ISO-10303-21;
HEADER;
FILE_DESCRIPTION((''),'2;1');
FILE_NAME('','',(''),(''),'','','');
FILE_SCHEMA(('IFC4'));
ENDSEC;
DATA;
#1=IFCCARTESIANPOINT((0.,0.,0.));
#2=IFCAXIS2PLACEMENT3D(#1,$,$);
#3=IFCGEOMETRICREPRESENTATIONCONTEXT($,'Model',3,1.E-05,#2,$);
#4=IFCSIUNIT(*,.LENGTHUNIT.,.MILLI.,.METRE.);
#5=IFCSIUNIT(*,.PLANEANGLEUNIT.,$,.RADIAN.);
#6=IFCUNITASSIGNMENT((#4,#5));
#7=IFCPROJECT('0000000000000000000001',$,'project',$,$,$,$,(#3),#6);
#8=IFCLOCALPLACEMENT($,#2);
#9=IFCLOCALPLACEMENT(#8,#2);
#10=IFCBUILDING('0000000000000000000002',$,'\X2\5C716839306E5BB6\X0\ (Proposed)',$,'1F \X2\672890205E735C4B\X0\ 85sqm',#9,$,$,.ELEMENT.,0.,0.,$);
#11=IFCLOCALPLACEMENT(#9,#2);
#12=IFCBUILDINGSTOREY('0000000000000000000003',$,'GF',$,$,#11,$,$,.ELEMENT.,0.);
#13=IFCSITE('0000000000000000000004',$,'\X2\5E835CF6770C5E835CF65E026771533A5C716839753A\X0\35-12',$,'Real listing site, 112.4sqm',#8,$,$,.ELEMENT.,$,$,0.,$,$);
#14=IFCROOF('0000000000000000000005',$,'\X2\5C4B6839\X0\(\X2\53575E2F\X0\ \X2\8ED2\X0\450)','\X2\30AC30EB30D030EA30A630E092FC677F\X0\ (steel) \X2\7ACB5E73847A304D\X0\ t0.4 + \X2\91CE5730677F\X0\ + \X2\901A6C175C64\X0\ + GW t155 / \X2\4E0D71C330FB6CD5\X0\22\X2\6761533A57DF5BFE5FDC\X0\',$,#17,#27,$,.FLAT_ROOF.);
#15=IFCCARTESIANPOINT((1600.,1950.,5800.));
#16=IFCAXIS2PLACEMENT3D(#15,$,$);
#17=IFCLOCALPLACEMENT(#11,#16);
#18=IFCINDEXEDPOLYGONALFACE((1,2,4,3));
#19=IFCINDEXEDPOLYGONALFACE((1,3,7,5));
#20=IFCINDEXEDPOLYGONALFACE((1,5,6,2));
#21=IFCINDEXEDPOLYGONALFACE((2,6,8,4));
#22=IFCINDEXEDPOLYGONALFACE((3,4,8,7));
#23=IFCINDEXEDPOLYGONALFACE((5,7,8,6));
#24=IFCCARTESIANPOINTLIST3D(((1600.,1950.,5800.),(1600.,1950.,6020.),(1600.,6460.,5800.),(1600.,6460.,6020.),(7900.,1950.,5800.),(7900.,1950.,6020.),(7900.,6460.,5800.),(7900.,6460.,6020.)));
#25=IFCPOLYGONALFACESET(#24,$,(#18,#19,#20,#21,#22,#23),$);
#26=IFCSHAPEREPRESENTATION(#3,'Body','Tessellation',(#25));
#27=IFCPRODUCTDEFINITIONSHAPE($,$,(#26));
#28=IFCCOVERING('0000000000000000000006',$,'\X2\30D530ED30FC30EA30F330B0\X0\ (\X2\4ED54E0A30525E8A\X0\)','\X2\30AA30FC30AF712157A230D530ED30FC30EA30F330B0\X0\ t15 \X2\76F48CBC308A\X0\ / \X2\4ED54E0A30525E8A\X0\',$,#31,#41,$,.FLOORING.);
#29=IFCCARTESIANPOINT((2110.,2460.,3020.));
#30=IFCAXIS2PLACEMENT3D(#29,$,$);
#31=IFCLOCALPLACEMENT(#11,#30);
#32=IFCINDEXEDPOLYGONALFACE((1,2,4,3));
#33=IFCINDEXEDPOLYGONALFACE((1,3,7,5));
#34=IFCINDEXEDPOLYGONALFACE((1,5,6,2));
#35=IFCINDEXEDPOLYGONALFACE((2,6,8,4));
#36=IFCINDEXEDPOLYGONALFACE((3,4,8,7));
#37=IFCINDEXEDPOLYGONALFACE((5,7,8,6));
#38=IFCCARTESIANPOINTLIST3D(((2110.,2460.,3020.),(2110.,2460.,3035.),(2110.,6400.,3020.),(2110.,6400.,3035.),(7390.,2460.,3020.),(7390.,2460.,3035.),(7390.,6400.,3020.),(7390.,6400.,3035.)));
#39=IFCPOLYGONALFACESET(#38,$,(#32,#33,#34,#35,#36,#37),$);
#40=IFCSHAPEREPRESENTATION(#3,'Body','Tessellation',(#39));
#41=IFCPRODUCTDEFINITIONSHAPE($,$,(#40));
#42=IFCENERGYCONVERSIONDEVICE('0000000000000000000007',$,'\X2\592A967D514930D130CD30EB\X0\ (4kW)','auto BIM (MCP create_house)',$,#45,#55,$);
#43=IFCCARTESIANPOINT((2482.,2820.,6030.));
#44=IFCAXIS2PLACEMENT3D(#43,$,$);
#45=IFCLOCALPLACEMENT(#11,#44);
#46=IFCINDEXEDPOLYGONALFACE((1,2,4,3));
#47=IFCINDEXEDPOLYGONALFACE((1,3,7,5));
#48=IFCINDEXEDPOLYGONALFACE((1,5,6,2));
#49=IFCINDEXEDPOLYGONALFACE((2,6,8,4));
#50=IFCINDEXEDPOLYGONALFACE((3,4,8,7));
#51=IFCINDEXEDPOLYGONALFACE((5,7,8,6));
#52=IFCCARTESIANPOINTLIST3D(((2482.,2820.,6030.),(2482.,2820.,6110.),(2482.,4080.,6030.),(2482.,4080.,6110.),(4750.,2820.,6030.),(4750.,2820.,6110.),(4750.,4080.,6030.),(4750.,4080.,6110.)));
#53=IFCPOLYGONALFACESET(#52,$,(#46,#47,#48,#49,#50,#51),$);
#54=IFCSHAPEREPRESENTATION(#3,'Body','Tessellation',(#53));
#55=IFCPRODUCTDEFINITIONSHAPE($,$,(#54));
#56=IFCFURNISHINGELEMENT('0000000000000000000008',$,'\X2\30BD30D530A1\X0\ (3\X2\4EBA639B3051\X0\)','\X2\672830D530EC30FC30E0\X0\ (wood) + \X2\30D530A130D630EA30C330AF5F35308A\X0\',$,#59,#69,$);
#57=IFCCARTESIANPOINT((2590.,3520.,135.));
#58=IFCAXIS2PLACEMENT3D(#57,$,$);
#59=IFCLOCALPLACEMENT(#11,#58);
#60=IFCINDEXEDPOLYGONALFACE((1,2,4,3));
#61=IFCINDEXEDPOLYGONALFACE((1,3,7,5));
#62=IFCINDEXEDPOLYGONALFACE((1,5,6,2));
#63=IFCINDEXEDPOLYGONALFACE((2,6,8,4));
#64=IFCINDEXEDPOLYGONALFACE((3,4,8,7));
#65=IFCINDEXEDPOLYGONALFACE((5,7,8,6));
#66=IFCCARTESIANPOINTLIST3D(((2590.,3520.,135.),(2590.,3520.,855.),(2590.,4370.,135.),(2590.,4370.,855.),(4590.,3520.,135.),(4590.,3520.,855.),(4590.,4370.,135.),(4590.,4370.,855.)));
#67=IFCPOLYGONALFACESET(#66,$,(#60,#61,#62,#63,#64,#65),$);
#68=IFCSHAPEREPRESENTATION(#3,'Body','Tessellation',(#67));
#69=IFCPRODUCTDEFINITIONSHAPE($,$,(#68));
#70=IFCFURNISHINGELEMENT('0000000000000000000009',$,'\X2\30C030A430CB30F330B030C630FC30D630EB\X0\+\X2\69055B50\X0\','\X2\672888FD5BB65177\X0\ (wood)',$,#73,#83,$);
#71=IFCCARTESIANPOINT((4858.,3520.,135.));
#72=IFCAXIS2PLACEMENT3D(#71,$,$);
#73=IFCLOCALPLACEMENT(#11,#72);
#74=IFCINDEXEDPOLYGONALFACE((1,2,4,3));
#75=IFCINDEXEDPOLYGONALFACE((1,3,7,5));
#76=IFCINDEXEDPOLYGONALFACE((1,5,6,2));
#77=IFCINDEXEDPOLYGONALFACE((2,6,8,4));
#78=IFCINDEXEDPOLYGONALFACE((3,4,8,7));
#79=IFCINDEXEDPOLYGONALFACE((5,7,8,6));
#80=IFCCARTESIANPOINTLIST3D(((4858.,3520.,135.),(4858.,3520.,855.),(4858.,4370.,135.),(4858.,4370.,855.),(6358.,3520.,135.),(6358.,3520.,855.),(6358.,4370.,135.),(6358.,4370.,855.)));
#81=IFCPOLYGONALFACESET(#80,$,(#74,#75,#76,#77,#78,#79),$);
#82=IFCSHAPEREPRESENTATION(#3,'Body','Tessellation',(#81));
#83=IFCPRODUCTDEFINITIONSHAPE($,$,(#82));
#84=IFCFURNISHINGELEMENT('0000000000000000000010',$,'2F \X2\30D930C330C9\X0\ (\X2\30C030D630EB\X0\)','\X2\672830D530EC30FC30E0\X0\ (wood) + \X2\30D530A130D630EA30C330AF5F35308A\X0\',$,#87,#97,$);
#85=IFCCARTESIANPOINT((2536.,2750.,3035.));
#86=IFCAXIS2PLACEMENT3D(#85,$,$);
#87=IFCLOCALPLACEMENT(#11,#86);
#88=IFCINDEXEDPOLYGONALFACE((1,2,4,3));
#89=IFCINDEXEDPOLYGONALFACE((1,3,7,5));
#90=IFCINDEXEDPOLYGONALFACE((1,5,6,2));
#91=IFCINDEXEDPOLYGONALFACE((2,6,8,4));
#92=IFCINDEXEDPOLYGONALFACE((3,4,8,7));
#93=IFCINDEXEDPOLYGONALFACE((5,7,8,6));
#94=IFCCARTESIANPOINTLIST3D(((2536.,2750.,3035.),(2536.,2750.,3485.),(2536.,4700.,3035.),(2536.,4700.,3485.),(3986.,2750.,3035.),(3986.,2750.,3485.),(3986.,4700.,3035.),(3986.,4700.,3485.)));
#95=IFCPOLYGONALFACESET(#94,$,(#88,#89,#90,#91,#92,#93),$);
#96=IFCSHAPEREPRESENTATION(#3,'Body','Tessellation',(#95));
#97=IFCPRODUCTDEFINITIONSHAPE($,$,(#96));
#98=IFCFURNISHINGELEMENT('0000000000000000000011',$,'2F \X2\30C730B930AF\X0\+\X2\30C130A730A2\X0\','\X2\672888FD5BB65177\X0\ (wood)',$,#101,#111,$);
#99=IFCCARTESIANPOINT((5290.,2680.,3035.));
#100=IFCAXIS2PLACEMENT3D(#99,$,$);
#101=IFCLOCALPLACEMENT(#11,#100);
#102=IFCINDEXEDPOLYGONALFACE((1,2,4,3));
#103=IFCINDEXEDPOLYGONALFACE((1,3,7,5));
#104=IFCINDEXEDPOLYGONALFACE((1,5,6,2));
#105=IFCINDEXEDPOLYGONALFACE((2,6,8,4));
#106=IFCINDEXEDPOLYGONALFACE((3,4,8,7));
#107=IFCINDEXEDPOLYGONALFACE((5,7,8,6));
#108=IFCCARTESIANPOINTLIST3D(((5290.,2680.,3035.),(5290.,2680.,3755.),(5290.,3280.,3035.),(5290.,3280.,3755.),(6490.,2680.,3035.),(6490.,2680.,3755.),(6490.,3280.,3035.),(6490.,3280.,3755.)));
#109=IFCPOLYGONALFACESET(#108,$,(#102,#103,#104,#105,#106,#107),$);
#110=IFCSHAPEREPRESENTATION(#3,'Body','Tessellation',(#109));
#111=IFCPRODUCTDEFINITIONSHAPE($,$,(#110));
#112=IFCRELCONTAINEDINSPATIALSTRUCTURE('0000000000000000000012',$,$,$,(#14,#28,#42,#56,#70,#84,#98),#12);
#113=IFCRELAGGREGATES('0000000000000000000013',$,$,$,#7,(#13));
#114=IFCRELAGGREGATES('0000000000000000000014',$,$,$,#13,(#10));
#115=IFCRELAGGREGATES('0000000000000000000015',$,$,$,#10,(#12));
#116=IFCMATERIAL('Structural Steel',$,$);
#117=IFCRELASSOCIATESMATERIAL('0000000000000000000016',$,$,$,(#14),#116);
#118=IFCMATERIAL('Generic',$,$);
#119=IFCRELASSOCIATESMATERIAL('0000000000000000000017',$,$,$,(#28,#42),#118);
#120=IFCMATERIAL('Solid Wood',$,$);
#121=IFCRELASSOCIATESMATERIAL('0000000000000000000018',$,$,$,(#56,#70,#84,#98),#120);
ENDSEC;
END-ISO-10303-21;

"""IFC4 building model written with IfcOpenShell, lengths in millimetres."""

from ifc_helpers import new_model, si_unit, frame, frame_2d, origin, place, context, project, spatial, rectangle, extrude, material, element, save


model = new_model("IFC4")

# Units and contexts
model_context = context("Model", 3, precision=1e-05, world=origin())
ifc_project = project(units=[si_unit("LENGTHUNIT", "METRE", prefix="MILLI"), si_unit("PLANEANGLEUNIT", "RADIAN")], contexts=[model_context])

# Site, building, storey
site_placement = place(None, origin())
site = spatial("IfcSite", under=ifc_project, at=site_placement, Name="広島県広島市東区山根町35-12", ObjectType="Real listing site, 112.4sqm", CompositionType="ELEMENT", RefElevation=0.0)
building_placement = place(site_placement, origin())
building = spatial("IfcBuilding", under=site, at=building_placement, Name="山根の家 (Proposed)", ObjectType="1F 木造平屋 85sqm", CompositionType="ELEMENT", ElevationOfRefHeight=0.0, ElevationOfTerrain=0.0)
storey_placement = place(building_placement, origin())
storey = spatial("IfcBuildingStorey", under=building, at=storey_placement, Name="GF", CompositionType="ELEMENT", Elevation=0.0)

# Shared definitions
ifc_material_1 = material(Name="Solid Wood")

# Shared definitions
ifc_material_2 = material(Name="Generic")

# Roof
ifc_material_3 = material(Name="Structural Steel")
for number, where, name in (
    (1, (1600.0, 1950.0, 5800.0), "屋根(南帯 軒450)"),
):
    element("IfcRoof", number, at=place(storey_placement, frame(where)), inside=storey, material=ifc_material_3, Name=name, Description="ガルバリウム鋼板 (steel) 立平葺き t0.4 + 野地板 + 通気層 + GW t155 / 不燃・法22条区域対応", PredefinedType="FLAT_ROOF", context=model_context, shape_type="SweptSolid", body=[
        extrude(rectangle(XDim=6300.0, YDim=4510.0, at=frame_2d((3150.0, 2255.0))), frame((1600.0, 1950.0, 5800.0)), (0.0, 0.0, 1.0), 220.0),
    ])

# Covering
covering_placement = place(storey_placement, frame((2110.0, 2460.0, 3020.0)))
element("IfcCovering", 2, at=covering_placement, inside=storey, material=ifc_material_2, Name="フローリング (仕上げ床)", Description="オーク無垢フローリング t15 直貼り / 仕上げ床", PredefinedType="FLOORING", context=model_context, shape_type="SweptSolid", body=[
    extrude(rectangle(XDim=5280.0, YDim=3940.0, at=frame_2d((2640.0, 1970.0))), frame((2110.0, 2460.0, 3020.0)), (0.0, 0.0, 1.0), 15.0),
])

# Energy conversion device
energy_conversion_device_placement = place(storey_placement, frame((2482.0, 2820.0, 6030.0)))
element("IfcEnergyConversionDevice", 3, at=energy_conversion_device_placement, inside=storey, material=ifc_material_2, Name="太陽光パネル (4kW)", Description="auto BIM (MCP create_house)", context=model_context, shape_type="SweptSolid", body=[
    extrude(rectangle(XDim=2268.0, YDim=1260.0, at=frame_2d((1134.0, 630.0))), frame((2482.0, 2820.0, 6030.0)), (0.0, 0.0, 1.0), 80.0),
])

# Furnishing elements
furnishing_1_placement = place(storey_placement, frame((2590.0, 3520.0, 135.0)))
element("IfcFurnishingElement", 4, at=furnishing_1_placement, inside=storey, material=ifc_material_1, Name="ソファ (3人掛け)", Description="木フレーム (wood) + ファブリック張り", context=model_context, shape_type="SweptSolid", body=[
    extrude(rectangle(XDim=2000.0, YDim=850.0, at=frame_2d((1000.0, 425.0))), frame((2590.0, 3520.0, 135.0)), (0.0, 0.0, 1.0), 720.0),
])
furnishing_2_placement = place(storey_placement, frame((4858.0, 3520.0, 135.0)))
element("IfcFurnishingElement", 5, at=furnishing_2_placement, inside=storey, material=ifc_material_1, Name="ダイニングテーブル+椅子", Description="木製家具 (wood)", context=model_context, shape_type="SweptSolid", body=[
    extrude(rectangle(XDim=1500.0, YDim=850.0, at=frame_2d((750.0, 425.0))), frame((4858.0, 3520.0, 135.0)), (0.0, 0.0, 1.0), 720.0),
])
furnishing_3_placement = place(storey_placement, frame((2536.0, 2750.0, 3035.0)))
element("IfcFurnishingElement", 6, at=furnishing_3_placement, inside=storey, material=ifc_material_1, Name="2F ベッド (ダブル)", Description="木フレーム (wood) + ファブリック張り", context=model_context, shape_type="SweptSolid", body=[
    extrude(rectangle(XDim=1450.0, YDim=1950.0, at=frame_2d((725.0, 975.0))), frame((2536.0, 2750.0, 3035.0)), (0.0, 0.0, 1.0), 450.0),
])
furnishing_4_placement = place(storey_placement, frame((5290.0, 2680.0, 3035.0)))
element("IfcFurnishingElement", 7, at=furnishing_4_placement, inside=storey, material=ifc_material_1, Name="2F デスク+チェア", Description="木製家具 (wood)", context=model_context, shape_type="SweptSolid", body=[
    extrude(rectangle(XDim=1200.0, YDim=600.0, at=frame_2d((600.0, 300.0))), frame((5290.0, 2680.0, 3035.0)), (0.0, 0.0, 1.0), 720.0),
])

save(model, "model.ifc")
